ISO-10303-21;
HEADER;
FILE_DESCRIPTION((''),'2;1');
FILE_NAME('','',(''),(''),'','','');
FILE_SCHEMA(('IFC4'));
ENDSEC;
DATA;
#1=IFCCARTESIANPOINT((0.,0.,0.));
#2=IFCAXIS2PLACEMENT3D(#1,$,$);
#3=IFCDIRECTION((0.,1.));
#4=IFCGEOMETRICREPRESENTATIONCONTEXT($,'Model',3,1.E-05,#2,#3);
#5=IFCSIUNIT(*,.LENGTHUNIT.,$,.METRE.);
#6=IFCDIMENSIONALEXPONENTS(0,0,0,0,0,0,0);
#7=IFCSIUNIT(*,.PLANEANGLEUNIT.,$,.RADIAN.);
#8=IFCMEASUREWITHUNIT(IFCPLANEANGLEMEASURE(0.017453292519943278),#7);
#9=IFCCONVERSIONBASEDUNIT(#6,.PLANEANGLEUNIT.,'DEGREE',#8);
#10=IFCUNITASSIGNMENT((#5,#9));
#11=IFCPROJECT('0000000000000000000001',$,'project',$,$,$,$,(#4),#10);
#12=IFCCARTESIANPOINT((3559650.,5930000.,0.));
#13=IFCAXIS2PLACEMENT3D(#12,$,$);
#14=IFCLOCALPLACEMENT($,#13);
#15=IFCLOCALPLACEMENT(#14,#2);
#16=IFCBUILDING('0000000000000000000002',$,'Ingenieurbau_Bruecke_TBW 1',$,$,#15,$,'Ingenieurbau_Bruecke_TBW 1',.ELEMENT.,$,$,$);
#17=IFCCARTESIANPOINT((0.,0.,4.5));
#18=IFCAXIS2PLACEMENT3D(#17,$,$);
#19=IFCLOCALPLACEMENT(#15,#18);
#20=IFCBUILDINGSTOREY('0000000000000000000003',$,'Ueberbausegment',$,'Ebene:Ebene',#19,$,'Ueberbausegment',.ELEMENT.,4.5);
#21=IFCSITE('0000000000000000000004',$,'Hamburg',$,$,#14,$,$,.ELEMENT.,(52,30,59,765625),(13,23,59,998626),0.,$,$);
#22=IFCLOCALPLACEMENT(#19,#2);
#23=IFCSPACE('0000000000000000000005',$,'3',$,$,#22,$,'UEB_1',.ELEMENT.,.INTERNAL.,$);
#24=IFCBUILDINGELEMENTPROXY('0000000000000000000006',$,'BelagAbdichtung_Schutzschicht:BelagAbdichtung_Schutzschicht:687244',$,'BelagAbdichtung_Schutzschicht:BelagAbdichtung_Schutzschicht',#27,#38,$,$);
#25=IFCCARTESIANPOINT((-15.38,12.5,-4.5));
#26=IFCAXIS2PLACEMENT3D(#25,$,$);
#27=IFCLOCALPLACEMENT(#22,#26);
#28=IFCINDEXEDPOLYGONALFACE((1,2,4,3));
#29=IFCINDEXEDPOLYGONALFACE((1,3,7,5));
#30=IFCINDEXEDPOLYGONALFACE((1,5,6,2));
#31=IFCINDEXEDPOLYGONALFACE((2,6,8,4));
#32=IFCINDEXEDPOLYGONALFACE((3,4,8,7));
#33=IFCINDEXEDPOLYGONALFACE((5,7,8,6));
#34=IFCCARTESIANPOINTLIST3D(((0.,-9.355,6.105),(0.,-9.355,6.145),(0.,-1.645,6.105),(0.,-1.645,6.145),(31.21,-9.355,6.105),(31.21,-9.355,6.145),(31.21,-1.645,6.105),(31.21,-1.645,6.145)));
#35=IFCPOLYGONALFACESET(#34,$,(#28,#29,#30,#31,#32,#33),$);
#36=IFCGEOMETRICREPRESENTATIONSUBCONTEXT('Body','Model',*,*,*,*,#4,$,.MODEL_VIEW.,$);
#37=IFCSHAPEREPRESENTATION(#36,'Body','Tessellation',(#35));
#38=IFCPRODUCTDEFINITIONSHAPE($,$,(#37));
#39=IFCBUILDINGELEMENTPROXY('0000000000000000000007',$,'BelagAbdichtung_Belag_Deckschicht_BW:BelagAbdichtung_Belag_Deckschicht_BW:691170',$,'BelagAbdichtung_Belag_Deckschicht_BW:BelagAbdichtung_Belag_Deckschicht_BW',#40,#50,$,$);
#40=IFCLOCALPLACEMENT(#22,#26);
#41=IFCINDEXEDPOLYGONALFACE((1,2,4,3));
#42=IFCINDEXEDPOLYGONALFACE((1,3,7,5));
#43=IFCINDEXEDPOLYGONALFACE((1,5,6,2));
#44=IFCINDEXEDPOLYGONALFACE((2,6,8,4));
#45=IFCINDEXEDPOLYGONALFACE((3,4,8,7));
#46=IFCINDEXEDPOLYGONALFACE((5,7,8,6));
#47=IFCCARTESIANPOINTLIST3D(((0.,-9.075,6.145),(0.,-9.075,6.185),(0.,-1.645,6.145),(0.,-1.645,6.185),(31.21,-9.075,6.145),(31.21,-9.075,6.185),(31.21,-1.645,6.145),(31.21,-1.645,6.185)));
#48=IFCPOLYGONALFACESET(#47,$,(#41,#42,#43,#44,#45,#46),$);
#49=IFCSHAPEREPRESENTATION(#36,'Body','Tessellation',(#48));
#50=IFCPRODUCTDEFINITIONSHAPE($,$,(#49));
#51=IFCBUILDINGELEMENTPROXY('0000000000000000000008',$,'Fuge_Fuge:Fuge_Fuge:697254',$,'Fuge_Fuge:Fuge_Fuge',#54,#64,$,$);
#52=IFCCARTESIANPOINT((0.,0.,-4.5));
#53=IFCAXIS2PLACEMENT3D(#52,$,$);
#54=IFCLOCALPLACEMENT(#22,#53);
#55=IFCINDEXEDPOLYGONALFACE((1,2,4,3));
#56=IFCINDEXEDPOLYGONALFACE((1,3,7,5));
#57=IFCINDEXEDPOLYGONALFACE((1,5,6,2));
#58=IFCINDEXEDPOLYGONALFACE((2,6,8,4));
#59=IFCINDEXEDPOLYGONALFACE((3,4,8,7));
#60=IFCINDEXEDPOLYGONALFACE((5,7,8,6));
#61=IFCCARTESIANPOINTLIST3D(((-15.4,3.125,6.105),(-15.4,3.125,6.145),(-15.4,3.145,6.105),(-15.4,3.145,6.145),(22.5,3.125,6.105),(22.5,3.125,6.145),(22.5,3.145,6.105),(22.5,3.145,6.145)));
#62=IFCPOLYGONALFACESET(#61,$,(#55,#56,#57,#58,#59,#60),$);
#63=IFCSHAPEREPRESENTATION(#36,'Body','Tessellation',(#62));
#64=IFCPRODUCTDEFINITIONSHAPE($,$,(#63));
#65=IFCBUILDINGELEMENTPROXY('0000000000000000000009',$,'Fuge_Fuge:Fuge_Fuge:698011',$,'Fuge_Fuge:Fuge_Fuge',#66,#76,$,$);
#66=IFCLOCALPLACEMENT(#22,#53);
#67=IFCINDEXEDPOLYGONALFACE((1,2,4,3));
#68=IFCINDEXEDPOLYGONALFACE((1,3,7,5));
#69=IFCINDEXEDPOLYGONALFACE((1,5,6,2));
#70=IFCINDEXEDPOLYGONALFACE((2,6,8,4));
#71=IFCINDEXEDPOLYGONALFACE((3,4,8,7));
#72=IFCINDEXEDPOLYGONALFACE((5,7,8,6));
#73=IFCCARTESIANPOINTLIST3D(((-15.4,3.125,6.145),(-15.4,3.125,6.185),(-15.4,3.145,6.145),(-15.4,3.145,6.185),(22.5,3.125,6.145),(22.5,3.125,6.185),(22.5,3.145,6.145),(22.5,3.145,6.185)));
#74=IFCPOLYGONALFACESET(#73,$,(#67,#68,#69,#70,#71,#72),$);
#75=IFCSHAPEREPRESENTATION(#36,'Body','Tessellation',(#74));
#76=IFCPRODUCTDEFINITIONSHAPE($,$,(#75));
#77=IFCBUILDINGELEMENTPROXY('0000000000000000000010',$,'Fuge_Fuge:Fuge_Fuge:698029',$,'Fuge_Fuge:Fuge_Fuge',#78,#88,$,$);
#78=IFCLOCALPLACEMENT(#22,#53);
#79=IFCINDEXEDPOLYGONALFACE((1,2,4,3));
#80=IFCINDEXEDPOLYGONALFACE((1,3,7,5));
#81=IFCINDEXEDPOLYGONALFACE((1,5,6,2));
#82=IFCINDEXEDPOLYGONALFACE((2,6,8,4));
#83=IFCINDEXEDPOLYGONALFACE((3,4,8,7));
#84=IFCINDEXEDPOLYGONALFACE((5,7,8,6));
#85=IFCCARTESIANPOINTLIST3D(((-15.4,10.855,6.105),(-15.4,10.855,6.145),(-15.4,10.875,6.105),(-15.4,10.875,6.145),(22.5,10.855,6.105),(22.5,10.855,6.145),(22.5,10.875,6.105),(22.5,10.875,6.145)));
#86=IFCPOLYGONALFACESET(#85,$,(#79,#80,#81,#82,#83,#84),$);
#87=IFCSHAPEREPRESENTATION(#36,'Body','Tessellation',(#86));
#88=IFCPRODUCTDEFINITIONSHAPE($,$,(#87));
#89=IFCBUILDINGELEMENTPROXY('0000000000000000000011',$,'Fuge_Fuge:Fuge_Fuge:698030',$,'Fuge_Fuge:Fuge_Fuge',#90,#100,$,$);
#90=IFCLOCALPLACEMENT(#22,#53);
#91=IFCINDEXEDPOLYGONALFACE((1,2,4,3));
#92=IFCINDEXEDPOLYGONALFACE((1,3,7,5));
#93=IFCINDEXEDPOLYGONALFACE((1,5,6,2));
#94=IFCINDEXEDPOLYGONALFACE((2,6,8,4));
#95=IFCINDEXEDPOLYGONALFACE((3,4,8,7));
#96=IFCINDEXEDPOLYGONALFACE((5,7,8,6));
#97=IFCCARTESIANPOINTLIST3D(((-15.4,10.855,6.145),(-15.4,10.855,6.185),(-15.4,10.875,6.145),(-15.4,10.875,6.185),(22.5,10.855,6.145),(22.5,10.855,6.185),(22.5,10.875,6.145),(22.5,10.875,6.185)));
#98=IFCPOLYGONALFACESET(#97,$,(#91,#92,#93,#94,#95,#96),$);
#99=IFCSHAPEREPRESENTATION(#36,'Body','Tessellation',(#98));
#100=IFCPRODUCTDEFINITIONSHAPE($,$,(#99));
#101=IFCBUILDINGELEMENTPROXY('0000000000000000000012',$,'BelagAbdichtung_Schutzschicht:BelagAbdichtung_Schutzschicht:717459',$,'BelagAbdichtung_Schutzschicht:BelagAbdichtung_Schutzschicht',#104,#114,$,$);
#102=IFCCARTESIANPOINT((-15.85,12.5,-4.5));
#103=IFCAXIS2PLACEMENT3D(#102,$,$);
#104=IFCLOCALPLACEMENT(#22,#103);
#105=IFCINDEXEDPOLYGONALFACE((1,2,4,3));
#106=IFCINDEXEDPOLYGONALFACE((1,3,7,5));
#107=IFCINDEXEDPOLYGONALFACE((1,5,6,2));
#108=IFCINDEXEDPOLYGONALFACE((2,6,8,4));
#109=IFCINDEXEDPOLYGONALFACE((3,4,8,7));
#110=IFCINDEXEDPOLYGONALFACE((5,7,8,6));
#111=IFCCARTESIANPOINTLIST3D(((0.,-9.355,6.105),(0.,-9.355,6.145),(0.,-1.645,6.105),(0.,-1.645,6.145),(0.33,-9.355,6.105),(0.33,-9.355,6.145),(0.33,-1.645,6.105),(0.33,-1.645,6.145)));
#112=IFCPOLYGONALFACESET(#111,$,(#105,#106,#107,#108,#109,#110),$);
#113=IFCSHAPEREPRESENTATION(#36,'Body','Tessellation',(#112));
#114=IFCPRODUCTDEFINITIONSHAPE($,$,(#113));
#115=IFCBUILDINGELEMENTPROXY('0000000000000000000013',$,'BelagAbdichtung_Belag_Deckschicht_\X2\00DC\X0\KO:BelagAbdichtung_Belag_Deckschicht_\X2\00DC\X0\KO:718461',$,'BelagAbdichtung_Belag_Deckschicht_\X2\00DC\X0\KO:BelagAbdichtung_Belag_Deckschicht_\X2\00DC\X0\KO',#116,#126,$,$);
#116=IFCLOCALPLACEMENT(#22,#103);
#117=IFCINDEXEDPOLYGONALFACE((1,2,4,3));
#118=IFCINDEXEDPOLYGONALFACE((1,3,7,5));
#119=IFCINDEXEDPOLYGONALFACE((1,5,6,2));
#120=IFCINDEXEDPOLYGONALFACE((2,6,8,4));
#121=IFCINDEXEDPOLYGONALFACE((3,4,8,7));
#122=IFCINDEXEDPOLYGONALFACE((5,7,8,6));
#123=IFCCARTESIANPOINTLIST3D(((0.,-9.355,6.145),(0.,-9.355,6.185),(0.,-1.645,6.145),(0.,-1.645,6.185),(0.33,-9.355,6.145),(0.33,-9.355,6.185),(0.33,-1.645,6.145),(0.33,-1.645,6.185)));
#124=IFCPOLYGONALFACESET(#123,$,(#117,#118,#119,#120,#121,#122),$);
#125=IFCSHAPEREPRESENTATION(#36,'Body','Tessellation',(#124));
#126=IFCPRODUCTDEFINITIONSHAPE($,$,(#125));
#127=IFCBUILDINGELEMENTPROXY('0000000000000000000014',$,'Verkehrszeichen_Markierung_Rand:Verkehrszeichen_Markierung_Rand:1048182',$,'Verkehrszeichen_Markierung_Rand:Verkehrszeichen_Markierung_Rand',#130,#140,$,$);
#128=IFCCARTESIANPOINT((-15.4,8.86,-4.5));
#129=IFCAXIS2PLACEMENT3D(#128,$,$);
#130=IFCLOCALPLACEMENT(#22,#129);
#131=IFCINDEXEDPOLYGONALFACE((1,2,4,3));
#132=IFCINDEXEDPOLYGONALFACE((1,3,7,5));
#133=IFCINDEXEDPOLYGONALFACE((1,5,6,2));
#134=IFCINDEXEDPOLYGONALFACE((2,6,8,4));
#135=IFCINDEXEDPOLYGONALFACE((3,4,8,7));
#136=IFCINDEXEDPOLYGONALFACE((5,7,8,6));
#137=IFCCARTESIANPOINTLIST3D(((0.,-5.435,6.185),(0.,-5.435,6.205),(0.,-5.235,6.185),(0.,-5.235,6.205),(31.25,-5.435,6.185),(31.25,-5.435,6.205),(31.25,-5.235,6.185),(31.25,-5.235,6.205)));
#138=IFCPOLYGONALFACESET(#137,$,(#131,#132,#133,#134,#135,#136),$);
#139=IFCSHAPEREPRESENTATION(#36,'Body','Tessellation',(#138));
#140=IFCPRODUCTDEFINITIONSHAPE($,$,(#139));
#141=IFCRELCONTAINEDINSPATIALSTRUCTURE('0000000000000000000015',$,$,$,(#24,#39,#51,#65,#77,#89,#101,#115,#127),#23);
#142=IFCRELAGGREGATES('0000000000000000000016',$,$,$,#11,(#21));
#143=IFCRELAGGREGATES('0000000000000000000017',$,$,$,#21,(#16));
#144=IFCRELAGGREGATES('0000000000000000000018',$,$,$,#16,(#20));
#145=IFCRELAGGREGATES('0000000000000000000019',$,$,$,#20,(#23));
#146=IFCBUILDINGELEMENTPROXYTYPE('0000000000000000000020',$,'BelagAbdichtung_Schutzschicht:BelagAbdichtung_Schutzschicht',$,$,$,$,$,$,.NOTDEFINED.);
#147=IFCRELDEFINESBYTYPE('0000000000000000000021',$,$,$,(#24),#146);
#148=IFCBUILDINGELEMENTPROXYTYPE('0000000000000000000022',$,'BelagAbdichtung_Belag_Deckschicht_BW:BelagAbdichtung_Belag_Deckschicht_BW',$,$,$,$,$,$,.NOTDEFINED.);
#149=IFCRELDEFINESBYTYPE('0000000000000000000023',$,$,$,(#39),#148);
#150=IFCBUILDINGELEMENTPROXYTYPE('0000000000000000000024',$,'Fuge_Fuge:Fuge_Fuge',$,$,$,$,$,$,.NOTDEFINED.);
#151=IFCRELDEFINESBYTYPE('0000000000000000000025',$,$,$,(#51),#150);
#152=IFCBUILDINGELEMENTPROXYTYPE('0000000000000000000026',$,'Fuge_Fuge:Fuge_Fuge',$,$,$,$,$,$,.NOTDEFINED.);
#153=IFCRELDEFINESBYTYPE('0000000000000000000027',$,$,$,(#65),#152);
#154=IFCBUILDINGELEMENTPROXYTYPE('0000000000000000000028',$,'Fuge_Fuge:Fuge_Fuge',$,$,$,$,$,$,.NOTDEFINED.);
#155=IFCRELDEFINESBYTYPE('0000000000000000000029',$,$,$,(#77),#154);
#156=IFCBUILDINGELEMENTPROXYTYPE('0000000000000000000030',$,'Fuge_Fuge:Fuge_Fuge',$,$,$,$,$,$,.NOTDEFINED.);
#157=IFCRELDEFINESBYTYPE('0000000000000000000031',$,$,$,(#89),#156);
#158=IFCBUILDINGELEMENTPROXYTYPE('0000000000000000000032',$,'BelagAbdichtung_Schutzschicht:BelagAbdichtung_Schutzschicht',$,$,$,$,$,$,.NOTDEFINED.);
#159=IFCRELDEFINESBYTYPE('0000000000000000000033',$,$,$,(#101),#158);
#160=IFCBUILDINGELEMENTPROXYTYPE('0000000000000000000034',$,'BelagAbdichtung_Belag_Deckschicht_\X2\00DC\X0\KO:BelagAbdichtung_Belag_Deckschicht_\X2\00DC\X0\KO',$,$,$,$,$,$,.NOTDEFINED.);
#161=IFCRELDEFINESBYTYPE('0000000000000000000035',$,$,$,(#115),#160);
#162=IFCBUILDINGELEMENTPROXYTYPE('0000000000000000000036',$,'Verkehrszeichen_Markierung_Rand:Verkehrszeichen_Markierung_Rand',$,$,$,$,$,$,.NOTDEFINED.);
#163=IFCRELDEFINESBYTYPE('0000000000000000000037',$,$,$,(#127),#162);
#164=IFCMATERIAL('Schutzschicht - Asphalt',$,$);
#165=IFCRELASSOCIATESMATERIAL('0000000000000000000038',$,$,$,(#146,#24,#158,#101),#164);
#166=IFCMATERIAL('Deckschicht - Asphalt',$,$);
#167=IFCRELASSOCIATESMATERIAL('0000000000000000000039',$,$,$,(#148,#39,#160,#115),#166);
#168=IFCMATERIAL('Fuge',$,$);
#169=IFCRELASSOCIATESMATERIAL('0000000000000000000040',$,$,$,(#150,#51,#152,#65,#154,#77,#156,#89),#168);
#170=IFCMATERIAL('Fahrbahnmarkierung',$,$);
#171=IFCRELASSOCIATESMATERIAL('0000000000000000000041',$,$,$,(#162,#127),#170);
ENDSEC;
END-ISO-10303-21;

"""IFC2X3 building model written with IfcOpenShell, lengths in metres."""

from ifc_helpers import new_model, entity, si_unit, converted_unit, direction, frame, origin, origin_2d_with_axis, place, context, subcontext, project, spatial, rectangle, extrude, source, transform, mapped, material, type_object, type_shapes, element, save


model = new_model("IFC2X3")

# Units and contexts
model_context = context("Model", 3, precision=1e-05, world=origin(), true_north=direction((0.0, 1.0)))
body_context = subcontext(model_context, "Body", "Model", "MODEL_VIEW")
ifc_project = project(units=[si_unit("LENGTHUNIT", "METRE"), converted_unit("PLANEANGLEUNIT", "DEGREE", entity("IfcPlaneAngleMeasure", 0.017453292519943278), si_unit("PLANEANGLEUNIT", "RADIAN"), dimensions=[0, 0, 0, 0, 0, 0, 0])], contexts=[model_context])

# Site, building, storey, space
site_placement = place(None, frame((3559650.0, 5930000.0, 0.0)))
site = spatial("IfcSite", under=ifc_project, at=site_placement, Name="Hamburg", CompositionType="ELEMENT", RefLatitude=(52, 30, 59, 765625), RefLongitude=(13, 23, 59, 998626), RefElevation=0.0)
building_placement = place(site_placement, origin())
building = spatial("IfcBuilding", under=site, at=building_placement, Name="Ingenieurbau_Bruecke_TBW 1", LongName="Ingenieurbau_Bruecke_TBW 1", CompositionType="ELEMENT")
storey_placement = place(building_placement, frame((0.0, 0.0, 4.5)))
storey = spatial("IfcBuildingStorey", under=building, at=storey_placement, Name="Ueberbausegment", ObjectType="Ebene:Ebene", LongName="Ueberbausegment", CompositionType="ELEMENT", Elevation=4.5)
space_placement = place(storey_placement, origin())
space = spatial("IfcSpace", under=storey, at=space_placement, Name="3", LongName="UEB_1", CompositionType="ELEMENT", InteriorOrExteriorSpace="INTERNAL")

# Building element proxies
ifc_material_1 = material(Name="Schutzschicht - Asphalt")
building_element_proxy_type_1 = type_object("IfcBuildingElementProxyType", Name="BelagAbdichtung_Schutzschicht:BelagAbdichtung_Schutzschicht", PredefinedType="NOTDEFINED", material=ifc_material_1)
shared_shape_1 = source(origin(), body_context, "Body", "SweptSolid", [
    extrude(rectangle(XDim=31.21, YDim=7.71, at=origin_2d_with_axis()), frame((15.605, -5.5, 6.105), z_axis=(0.0, 0.0, 1.0), x_axis=(-1.0, 0.0, 0.0)), (0.0, 0.0, 1.0), 0.04),
])
type_shapes(building_element_proxy_type_1, [shared_shape_1])
proxy_1_placement = place(space_placement, frame((-15.38, 12.5, -4.5)))
element("IfcBuildingElementProxy", 1, at=proxy_1_placement, inside=space, type_object=building_element_proxy_type_1, material=ifc_material_1, Name="BelagAbdichtung_Schutzschicht:BelagAbdichtung_Schutzschicht:687244", ObjectType="BelagAbdichtung_Schutzschicht:BelagAbdichtung_Schutzschicht", context=body_context, shape_type="MappedRepresentation", body=[
    mapped(shared_shape_1, transform((0.0, 0.0, 0.0), scale=1.0)),
])
ifc_material_2 = material(Name="Deckschicht - Asphalt")
building_element_proxy_type_2 = type_object("IfcBuildingElementProxyType", Name="BelagAbdichtung_Belag_Deckschicht_BW:BelagAbdichtung_Belag_Deckschicht_BW", PredefinedType="NOTDEFINED", material=ifc_material_2)
shared_shape_2 = source(origin(), body_context, "Body", "SweptSolid", [
    extrude(rectangle(XDim=31.21, YDim=7.43, at=origin_2d_with_axis()), frame((15.605, -5.36, 6.145), z_axis=(0.0, 0.0, 1.0), x_axis=(-1.0, 0.0, 0.0)), (0.0, 0.0, 1.0), 0.04),
])
type_shapes(building_element_proxy_type_2, [shared_shape_2])
proxy_2_placement = place(space_placement, frame((-15.38, 12.5, -4.5)))
element("IfcBuildingElementProxy", 2, at=proxy_2_placement, inside=space, type_object=building_element_proxy_type_2, material=ifc_material_2, Name="BelagAbdichtung_Belag_Deckschicht_BW:BelagAbdichtung_Belag_Deckschicht_BW:691170", ObjectType="BelagAbdichtung_Belag_Deckschicht_BW:BelagAbdichtung_Belag_Deckschicht_BW", context=body_context, shape_type="MappedRepresentation", body=[
    mapped(shared_shape_2, transform((0.0, 0.0, 0.0), scale=1.0)),
])
ifc_material_3 = material(Name="Fuge")
building_element_proxy_type_3 = type_object("IfcBuildingElementProxyType", Name="Fuge_Fuge:Fuge_Fuge", PredefinedType="NOTDEFINED", material=ifc_material_3)
shared_shape_3 = source(origin(), body_context, "Body", "SweptSolid", [
    extrude(rectangle(XDim=37.9, YDim=0.02, at=origin_2d_with_axis()), frame((3.55, 3.135, 6.105), z_axis=(0.0, 0.0, 1.0), x_axis=(-1.0, 0.0, 0.0)), (0.0, 0.0, 1.0), 0.04),
])
type_shapes(building_element_proxy_type_3, [shared_shape_3])
proxy_3_placement = place(space_placement, frame((0.0, 0.0, -4.5)))
element("IfcBuildingElementProxy", 3, at=proxy_3_placement, inside=space, type_object=building_element_proxy_type_3, material=ifc_material_3, Name="Fuge_Fuge:Fuge_Fuge:697254", ObjectType="Fuge_Fuge:Fuge_Fuge", context=body_context, shape_type="MappedRepresentation", body=[
    mapped(shared_shape_3, transform((0.0, 0.0, 0.0), scale=1.0)),
])
building_element_proxy_type_4 = type_object("IfcBuildingElementProxyType", Name="Fuge_Fuge:Fuge_Fuge", PredefinedType="NOTDEFINED", material=ifc_material_3)
shared_shape_4 = source(origin(), body_context, "Body", "SweptSolid", [
    extrude(rectangle(XDim=37.9, YDim=0.02, at=origin_2d_with_axis()), frame((3.55, 3.135, 6.145), z_axis=(0.0, 0.0, 1.0), x_axis=(-1.0, 0.0, 0.0)), (0.0, 0.0, 1.0), 0.04),
])
type_shapes(building_element_proxy_type_4, [shared_shape_4])
proxy_4_placement = place(space_placement, frame((0.0, 0.0, -4.5)))
element("IfcBuildingElementProxy", 4, at=proxy_4_placement, inside=space, type_object=building_element_proxy_type_4, material=ifc_material_3, Name="Fuge_Fuge:Fuge_Fuge:698011", ObjectType="Fuge_Fuge:Fuge_Fuge", context=body_context, shape_type="MappedRepresentation", body=[
    mapped(shared_shape_4, transform((0.0, 0.0, 0.0), scale=1.0)),
])
building_element_proxy_type_5 = type_object("IfcBuildingElementProxyType", Name="Fuge_Fuge:Fuge_Fuge", PredefinedType="NOTDEFINED", material=ifc_material_3)
shared_shape_5 = source(origin(), body_context, "Body", "SweptSolid", [
    extrude(rectangle(XDim=37.9, YDim=0.02, at=origin_2d_with_axis()), frame((3.55, 10.865, 6.105), z_axis=(0.0, 0.0, 1.0), x_axis=(-1.0, 0.0, 0.0)), (0.0, 0.0, 1.0), 0.04),
])
type_shapes(building_element_proxy_type_5, [shared_shape_5])
proxy_5_placement = place(space_placement, frame((0.0, 0.0, -4.5)))
element("IfcBuildingElementProxy", 5, at=proxy_5_placement, inside=space, type_object=building_element_proxy_type_5, material=ifc_material_3, Name="Fuge_Fuge:Fuge_Fuge:698029", ObjectType="Fuge_Fuge:Fuge_Fuge", context=body_context, shape_type="MappedRepresentation", body=[
    mapped(shared_shape_5, transform((0.0, 0.0, 0.0), scale=1.0)),
])
building_element_proxy_type_6 = type_object("IfcBuildingElementProxyType", Name="Fuge_Fuge:Fuge_Fuge", PredefinedType="NOTDEFINED", material=ifc_material_3)
shared_shape_6 = source(origin(), body_context, "Body", "SweptSolid", [
    extrude(rectangle(XDim=37.9, YDim=0.02, at=origin_2d_with_axis()), frame((3.55, 10.865, 6.145), z_axis=(0.0, 0.0, 1.0), x_axis=(-1.0, 0.0, 0.0)), (0.0, 0.0, 1.0), 0.04),
])
type_shapes(building_element_proxy_type_6, [shared_shape_6])
proxy_6_placement = place(space_placement, frame((0.0, 0.0, -4.5)))
element("IfcBuildingElementProxy", 6, at=proxy_6_placement, inside=space, type_object=building_element_proxy_type_6, material=ifc_material_3, Name="Fuge_Fuge:Fuge_Fuge:698030", ObjectType="Fuge_Fuge:Fuge_Fuge", context=body_context, shape_type="MappedRepresentation", body=[
    mapped(shared_shape_6, transform((0.0, 0.0, 0.0), scale=1.0)),
])
building_element_proxy_type_7 = type_object("IfcBuildingElementProxyType", Name="BelagAbdichtung_Schutzschicht:BelagAbdichtung_Schutzschicht", PredefinedType="NOTDEFINED", material=ifc_material_1)
shared_shape_7 = source(origin(), body_context, "Body", "SweptSolid", [
    extrude(rectangle(XDim=0.33, YDim=7.71, at=origin_2d_with_axis()), frame((0.165, -5.5, 6.105), z_axis=(0.0, 0.0, 1.0), x_axis=(-1.0, 0.0, 0.0)), (0.0, 0.0, 1.0), 0.04),
])
type_shapes(building_element_proxy_type_7, [shared_shape_7])
proxy_7_placement = place(space_placement, frame((-15.85, 12.5, -4.5)))
element("IfcBuildingElementProxy", 7, at=proxy_7_placement, inside=space, type_object=building_element_proxy_type_7, material=ifc_material_1, Name="BelagAbdichtung_Schutzschicht:BelagAbdichtung_Schutzschicht:717459", ObjectType="BelagAbdichtung_Schutzschicht:BelagAbdichtung_Schutzschicht", context=body_context, shape_type="MappedRepresentation", body=[
    mapped(shared_shape_7, transform((0.0, 0.0, 0.0), scale=1.0)),
])
building_element_proxy_type_8 = type_object("IfcBuildingElementProxyType", Name="BelagAbdichtung_Belag_Deckschicht_ÜKO:BelagAbdichtung_Belag_Deckschicht_ÜKO", PredefinedType="NOTDEFINED", material=ifc_material_2)
shared_shape_8 = source(origin(), body_context, "Body", "SweptSolid", [
    extrude(rectangle(XDim=0.33, YDim=7.71, at=origin_2d_with_axis()), frame((0.165, -5.5, 6.145), z_axis=(0.0, 0.0, 1.0), x_axis=(-1.0, 0.0, 0.0)), (0.0, 0.0, 1.0), 0.04),
])
type_shapes(building_element_proxy_type_8, [shared_shape_8])
proxy_8_placement = place(space_placement, frame((-15.85, 12.5, -4.5)))
element("IfcBuildingElementProxy", 8, at=proxy_8_placement, inside=space, type_object=building_element_proxy_type_8, material=ifc_material_2, Name="BelagAbdichtung_Belag_Deckschicht_ÜKO:BelagAbdichtung_Belag_Deckschicht_ÜKO:718461", ObjectType="BelagAbdichtung_Belag_Deckschicht_ÜKO:BelagAbdichtung_Belag_Deckschicht_ÜKO", context=body_context, shape_type="MappedRepresentation", body=[
    mapped(shared_shape_8, transform((0.0, 0.0, 0.0), scale=1.0)),
])
ifc_material_4 = material(Name="Fahrbahnmarkierung")
building_element_proxy_type_9 = type_object("IfcBuildingElementProxyType", Name="Verkehrszeichen_Markierung_Rand:Verkehrszeichen_Markierung_Rand", PredefinedType="NOTDEFINED", material=ifc_material_4)
shared_shape_9 = source(origin(), body_context, "Body", "SweptSolid", [
    extrude(rectangle(XDim=31.25, YDim=0.2, at=origin_2d_with_axis()), frame((15.625, -5.335, 6.185), z_axis=(0.0, 0.0, 1.0), x_axis=(-1.0, 0.0, 0.0)), (0.0, 0.0, 1.0), 0.02),
])
type_shapes(building_element_proxy_type_9, [shared_shape_9])
proxy_9_placement = place(space_placement, frame((-15.4, 8.86, -4.5)))
element("IfcBuildingElementProxy", 9, at=proxy_9_placement, inside=space, type_object=building_element_proxy_type_9, material=ifc_material_4, Name="Verkehrszeichen_Markierung_Rand:Verkehrszeichen_Markierung_Rand:1048182", ObjectType="Verkehrszeichen_Markierung_Rand:Verkehrszeichen_Markierung_Rand", context=body_context, shape_type="MappedRepresentation", body=[
    mapped(shared_shape_9, transform((0.0, 0.0, 0.0), scale=1.0)),
])

save(model, "model.ifc")
